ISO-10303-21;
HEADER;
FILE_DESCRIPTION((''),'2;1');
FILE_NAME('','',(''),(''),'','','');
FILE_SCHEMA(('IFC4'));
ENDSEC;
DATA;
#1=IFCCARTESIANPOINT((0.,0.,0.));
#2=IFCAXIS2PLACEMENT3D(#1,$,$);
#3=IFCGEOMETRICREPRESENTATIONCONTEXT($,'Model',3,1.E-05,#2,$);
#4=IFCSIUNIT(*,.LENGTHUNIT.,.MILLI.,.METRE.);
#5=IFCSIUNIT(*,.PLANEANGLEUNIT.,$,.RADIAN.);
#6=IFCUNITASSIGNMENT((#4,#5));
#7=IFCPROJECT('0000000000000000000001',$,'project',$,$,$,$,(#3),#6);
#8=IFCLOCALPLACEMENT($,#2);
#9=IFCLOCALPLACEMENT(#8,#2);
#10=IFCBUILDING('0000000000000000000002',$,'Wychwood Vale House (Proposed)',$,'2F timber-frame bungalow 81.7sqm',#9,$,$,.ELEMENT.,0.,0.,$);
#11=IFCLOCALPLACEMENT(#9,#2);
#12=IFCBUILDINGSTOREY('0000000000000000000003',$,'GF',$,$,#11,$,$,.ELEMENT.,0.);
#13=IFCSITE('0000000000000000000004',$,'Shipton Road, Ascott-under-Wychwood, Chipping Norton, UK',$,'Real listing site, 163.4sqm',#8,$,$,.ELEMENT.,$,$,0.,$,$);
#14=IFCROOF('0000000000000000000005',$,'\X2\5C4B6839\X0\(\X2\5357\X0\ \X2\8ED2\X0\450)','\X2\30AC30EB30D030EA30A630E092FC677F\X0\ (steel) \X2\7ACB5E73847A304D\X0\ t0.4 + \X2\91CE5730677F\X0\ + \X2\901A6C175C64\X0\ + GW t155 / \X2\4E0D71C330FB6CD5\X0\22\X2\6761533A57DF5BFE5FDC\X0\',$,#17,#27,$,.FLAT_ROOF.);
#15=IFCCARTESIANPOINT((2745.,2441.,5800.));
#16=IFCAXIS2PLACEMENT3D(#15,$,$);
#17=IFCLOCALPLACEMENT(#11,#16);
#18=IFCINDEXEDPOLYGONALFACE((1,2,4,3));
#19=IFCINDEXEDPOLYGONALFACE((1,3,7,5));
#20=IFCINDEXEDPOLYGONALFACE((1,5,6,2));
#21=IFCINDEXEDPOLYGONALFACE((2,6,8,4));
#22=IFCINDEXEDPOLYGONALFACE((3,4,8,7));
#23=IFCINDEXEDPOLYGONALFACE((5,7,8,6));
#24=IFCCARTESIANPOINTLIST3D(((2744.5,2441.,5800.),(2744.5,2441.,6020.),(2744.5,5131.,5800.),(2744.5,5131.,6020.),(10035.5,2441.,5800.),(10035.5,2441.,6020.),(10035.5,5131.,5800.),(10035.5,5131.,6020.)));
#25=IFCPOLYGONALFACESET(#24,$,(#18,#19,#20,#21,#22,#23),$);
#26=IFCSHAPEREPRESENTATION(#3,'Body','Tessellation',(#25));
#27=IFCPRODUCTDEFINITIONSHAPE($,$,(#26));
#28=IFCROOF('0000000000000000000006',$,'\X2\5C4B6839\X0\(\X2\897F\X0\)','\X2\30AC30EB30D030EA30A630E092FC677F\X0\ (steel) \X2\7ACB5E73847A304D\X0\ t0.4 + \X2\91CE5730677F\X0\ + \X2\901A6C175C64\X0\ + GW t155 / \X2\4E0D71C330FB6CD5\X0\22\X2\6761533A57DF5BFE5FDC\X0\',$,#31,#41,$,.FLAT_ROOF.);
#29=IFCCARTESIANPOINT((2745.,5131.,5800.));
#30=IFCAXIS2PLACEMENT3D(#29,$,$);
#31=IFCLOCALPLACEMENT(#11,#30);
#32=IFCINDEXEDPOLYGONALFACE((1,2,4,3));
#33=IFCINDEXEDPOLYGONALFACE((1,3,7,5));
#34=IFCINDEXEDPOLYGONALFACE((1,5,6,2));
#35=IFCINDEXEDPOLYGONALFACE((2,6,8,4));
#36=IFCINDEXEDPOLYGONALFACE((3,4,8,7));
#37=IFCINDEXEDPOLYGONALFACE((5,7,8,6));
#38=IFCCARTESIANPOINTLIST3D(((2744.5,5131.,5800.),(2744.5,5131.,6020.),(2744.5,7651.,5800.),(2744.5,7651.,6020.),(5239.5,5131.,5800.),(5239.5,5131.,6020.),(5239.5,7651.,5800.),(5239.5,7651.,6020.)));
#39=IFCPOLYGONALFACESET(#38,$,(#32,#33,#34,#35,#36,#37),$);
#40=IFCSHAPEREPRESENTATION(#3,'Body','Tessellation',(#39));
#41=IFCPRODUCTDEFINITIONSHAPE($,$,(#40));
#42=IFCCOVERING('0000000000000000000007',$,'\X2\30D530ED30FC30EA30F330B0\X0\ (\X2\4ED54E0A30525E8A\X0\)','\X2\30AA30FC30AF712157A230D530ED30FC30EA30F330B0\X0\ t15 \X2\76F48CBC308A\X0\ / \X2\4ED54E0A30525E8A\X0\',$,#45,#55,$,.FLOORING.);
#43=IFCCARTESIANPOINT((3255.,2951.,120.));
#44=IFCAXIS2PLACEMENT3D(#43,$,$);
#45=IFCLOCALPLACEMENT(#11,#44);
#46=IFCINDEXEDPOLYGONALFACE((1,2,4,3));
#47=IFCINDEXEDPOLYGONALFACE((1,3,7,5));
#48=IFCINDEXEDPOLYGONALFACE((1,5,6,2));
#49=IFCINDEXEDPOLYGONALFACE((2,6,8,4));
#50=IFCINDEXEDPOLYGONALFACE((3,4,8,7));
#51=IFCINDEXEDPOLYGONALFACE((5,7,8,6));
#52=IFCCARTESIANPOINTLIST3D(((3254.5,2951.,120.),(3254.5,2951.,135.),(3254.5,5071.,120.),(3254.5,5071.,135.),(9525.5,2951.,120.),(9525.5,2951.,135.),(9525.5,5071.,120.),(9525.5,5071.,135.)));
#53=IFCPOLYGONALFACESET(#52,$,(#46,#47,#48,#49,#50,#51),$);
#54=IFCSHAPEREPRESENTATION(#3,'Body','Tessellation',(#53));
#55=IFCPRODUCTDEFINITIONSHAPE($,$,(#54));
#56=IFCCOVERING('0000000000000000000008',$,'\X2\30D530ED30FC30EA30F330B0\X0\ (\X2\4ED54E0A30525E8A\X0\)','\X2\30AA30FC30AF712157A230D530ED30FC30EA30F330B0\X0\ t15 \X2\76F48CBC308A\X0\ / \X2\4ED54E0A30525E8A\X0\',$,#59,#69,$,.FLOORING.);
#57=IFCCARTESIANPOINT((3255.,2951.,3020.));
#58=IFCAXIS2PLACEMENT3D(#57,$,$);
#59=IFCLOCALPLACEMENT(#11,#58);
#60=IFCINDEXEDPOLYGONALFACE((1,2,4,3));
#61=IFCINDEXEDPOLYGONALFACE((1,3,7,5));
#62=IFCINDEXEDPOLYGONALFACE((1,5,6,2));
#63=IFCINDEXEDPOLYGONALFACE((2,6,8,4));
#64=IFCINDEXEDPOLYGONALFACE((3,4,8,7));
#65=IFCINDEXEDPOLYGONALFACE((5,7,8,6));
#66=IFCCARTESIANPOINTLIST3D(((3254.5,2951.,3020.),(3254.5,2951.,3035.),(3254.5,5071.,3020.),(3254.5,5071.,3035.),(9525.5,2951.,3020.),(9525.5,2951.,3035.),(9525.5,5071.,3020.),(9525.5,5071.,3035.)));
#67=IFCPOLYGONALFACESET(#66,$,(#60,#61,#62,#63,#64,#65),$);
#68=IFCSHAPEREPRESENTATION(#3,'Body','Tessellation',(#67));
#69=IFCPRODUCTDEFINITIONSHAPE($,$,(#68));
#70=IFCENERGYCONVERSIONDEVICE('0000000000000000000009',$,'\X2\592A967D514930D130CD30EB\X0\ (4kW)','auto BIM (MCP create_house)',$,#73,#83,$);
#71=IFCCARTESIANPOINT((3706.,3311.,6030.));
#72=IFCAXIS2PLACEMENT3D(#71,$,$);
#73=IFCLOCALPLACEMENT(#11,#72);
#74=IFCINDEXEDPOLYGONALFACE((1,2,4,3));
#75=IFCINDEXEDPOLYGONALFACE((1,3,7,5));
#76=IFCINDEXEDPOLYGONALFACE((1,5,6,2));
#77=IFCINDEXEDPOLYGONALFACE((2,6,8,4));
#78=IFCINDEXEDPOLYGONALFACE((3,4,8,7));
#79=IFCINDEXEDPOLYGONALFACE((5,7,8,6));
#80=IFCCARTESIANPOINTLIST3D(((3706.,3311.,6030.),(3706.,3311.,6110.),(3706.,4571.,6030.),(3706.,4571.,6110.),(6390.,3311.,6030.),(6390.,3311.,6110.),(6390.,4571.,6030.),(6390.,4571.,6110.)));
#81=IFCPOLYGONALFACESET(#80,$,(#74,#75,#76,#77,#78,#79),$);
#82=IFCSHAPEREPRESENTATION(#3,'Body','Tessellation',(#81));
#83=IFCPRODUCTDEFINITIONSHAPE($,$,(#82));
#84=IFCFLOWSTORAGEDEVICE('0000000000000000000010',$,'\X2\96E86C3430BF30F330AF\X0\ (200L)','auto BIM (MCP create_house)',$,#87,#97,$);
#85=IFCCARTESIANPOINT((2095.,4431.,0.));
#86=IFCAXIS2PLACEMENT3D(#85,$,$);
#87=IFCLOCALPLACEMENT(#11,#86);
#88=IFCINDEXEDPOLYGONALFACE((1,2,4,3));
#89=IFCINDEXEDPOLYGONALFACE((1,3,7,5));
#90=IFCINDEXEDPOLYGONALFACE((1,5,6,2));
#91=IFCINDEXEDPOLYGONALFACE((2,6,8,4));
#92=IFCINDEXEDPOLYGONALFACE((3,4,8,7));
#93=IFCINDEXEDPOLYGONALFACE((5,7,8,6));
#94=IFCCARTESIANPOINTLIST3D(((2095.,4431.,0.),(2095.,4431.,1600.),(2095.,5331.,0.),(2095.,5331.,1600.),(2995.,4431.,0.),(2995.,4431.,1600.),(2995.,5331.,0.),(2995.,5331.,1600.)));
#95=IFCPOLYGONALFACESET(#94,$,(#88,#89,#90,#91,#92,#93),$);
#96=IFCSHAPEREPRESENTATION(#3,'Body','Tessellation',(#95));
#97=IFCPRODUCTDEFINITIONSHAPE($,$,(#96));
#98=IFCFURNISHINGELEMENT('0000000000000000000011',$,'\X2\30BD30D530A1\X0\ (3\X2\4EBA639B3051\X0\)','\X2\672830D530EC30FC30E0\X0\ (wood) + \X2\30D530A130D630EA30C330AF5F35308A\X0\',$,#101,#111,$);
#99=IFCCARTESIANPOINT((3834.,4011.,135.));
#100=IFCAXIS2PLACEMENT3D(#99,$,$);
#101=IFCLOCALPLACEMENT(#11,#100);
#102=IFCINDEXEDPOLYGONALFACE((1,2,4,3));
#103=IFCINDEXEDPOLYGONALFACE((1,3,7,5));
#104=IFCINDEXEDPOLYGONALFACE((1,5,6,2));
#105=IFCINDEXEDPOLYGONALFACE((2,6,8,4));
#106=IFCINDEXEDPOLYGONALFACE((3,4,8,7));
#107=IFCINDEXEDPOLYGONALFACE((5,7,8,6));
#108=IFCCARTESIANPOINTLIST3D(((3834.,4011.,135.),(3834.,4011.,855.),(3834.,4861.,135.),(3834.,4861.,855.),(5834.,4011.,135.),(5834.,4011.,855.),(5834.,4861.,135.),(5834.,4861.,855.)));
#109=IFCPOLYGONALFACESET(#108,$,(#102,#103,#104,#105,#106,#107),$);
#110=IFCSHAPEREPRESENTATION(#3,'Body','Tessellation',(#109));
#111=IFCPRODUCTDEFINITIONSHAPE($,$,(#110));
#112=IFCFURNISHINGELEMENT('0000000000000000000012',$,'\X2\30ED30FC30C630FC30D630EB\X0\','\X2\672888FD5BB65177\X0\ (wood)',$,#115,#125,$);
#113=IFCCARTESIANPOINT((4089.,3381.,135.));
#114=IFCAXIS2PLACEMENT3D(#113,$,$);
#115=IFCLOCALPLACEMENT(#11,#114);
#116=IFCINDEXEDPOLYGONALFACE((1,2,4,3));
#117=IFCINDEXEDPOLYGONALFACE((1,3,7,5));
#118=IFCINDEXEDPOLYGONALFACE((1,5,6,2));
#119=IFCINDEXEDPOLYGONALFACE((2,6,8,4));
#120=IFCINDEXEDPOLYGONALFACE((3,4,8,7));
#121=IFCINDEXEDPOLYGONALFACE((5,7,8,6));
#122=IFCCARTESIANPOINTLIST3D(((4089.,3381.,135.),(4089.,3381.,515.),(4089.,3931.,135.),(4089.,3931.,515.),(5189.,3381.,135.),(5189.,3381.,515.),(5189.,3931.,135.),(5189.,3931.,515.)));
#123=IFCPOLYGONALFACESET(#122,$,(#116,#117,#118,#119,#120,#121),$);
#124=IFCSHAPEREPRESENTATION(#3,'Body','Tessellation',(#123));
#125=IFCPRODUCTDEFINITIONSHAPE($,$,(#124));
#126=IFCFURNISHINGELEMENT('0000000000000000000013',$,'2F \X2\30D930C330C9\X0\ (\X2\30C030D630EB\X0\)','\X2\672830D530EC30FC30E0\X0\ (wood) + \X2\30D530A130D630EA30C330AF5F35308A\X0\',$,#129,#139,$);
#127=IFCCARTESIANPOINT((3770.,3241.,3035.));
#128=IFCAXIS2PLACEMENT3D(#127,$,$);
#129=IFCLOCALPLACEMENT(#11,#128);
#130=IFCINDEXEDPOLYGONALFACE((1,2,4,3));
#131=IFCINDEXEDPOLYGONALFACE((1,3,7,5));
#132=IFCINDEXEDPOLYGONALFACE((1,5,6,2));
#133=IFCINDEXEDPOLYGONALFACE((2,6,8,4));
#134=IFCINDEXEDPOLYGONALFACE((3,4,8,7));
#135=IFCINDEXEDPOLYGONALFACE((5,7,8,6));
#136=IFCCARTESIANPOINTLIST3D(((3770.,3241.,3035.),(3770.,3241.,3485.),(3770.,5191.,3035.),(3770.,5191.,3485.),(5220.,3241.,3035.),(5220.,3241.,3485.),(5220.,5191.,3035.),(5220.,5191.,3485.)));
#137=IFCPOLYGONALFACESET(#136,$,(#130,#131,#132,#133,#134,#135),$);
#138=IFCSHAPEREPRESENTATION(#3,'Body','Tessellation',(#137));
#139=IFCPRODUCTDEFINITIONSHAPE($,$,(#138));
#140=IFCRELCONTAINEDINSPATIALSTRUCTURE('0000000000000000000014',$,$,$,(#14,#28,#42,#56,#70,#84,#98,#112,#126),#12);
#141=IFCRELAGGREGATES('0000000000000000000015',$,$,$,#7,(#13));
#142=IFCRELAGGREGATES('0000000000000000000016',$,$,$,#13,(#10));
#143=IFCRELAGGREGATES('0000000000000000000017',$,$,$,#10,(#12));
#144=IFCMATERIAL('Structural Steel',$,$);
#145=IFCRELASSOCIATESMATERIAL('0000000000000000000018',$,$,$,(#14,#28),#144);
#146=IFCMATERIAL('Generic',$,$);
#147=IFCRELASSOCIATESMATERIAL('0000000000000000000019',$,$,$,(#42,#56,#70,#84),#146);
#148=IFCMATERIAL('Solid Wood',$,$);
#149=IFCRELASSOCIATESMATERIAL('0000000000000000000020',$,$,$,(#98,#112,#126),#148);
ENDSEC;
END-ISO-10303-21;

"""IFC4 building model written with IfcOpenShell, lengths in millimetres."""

from ifc_helpers import new_model, si_unit, frame, frame_2d, origin, place, context, project, spatial, rectangle, extrude, material, element, save


model = new_model("IFC4")

# Units and contexts
model_context = context("Model", 3, precision=1e-05, world=origin())
ifc_project = project(units=[si_unit("LENGTHUNIT", "METRE", prefix="MILLI"), si_unit("PLANEANGLEUNIT", "RADIAN")], contexts=[model_context])

# Site, building, storey
site_placement = place(None, origin())
site = spatial("IfcSite", under=ifc_project, at=site_placement, Name="Shipton Road, Ascott-under-Wychwood, Chipping Norton, UK", ObjectType="Real listing site, 163.4sqm", CompositionType="ELEMENT", RefElevation=0.0)
building_placement = place(site_placement, origin())
building = spatial("IfcBuilding", under=site, at=building_placement, Name="Wychwood Vale House (Proposed)", ObjectType="2F timber-frame bungalow 81.7sqm", CompositionType="ELEMENT", ElevationOfRefHeight=0.0, ElevationOfTerrain=0.0)
storey_placement = place(building_placement, origin())
storey = spatial("IfcBuildingStorey", under=building, at=storey_placement, Name="GF", CompositionType="ELEMENT", Elevation=0.0)

# Shared definitions
ifc_material_1 = material(Name="Solid Wood")

# Roofs
ifc_material_2 = material(Name="Structural Steel")
roof_1_placement = place(storey_placement, frame((2745.0, 2441.0, 5800.0)))
element("IfcRoof", 1, at=roof_1_placement, inside=storey, material=ifc_material_2, Name="屋根(南 軒450)", Description="ガルバリウム鋼板 (steel) 立平葺き t0.4 + 野地板 + 通気層 + GW t155 / 不燃・法22条区域対応", PredefinedType="FLAT_ROOF", context=model_context, shape_type="SweptSolid", body=[
    extrude(rectangle(XDim=7291.0, YDim=2690.0, at=frame_2d((3645.0, 1345.0))), frame((2745.0, 2441.0, 5800.0)), (0.0, 0.0, 1.0), 220.0),
])
roof_2_placement = place(storey_placement, frame((2745.0, 5131.0, 5800.0)))
element("IfcRoof", 2, at=roof_2_placement, inside=storey, material=ifc_material_2, Name="屋根(西)", Description="ガルバリウム鋼板 (steel) 立平葺き t0.4 + 野地板 + 通気層 + GW t155 / 不燃・法22条区域対応", PredefinedType="FLAT_ROOF", context=model_context, shape_type="SweptSolid", body=[
    extrude(rectangle(XDim=2495.0, YDim=2520.0, at=frame_2d((1247.0, 1260.0))), frame((2745.0, 5131.0, 5800.0)), (0.0, 0.0, 1.0), 220.0),
])

# Coverings
ifc_material_3 = material(Name="Generic")
covering_1_placement = place(storey_placement, frame((3255.0, 2951.0, 120.0)))
element("IfcCovering", 3, at=covering_1_placement, inside=storey, material=ifc_material_3, Name="フローリング (仕上げ床)", Description="オーク無垢フローリング t15 直貼り / 仕上げ床", PredefinedType="FLOORING", context=model_context, shape_type="SweptSolid", body=[
    extrude(rectangle(XDim=6271.0, YDim=2120.0, at=frame_2d((3135.0, 1060.0))), frame((3255.0, 2951.0, 120.0)), (0.0, 0.0, 1.0), 15.0),
])
covering_2_placement = place(storey_placement, frame((3255.0, 2951.0, 3020.0)))
element("IfcCovering", 4, at=covering_2_placement, inside=storey, material=ifc_material_3, Name="フローリング (仕上げ床)", Description="オーク無垢フローリング t15 直貼り / 仕上げ床", PredefinedType="FLOORING", context=model_context, shape_type="SweptSolid", body=[
    extrude(rectangle(XDim=6271.0, YDim=2120.0, at=frame_2d((3135.0, 1060.0))), frame((3255.0, 2951.0, 3020.0)), (0.0, 0.0, 1.0), 15.0),
])

# Energy conversion device
energy_conversion_device_placement = place(storey_placement, frame((3706.0, 3311.0, 6030.0)))
element("IfcEnergyConversionDevice", 5, at=energy_conversion_device_placement, inside=storey, material=ifc_material_3, Name="太陽光パネル (4kW)", Description="auto BIM (MCP create_house)", context=model_context, shape_type="SweptSolid", body=[
    extrude(rectangle(XDim=2684.0, YDim=1260.0, at=frame_2d((1342.0, 630.0))), frame((3706.0, 3311.0, 6030.0)), (0.0, 0.0, 1.0), 80.0),
])

# Flow storage device
flow_storage_device_placement = place(storey_placement, frame((2095.0, 4431.0, 0.0)))
element("IfcFlowStorageDevice", 6, at=flow_storage_device_placement, inside=storey, material=ifc_material_3, Name="雨水タンク (200L)", Description="auto BIM (MCP create_house)", context=model_context, shape_type="SweptSolid", body=[
    extrude(rectangle(XDim=900.0, YDim=900.0, at=frame_2d((450.0, 450.0))), frame((2095.0, 4431.0, 0.0)), (0.0, 0.0, 1.0), 1600.0),
])

# Furnishing elements
furnishing_1_placement = place(storey_placement, frame((3834.0, 4011.0, 135.0)))
element("IfcFurnishingElement", 7, at=furnishing_1_placement, inside=storey, material=ifc_material_1, Name="ソファ (3人掛け)", Description="木フレーム (wood) + ファブリック張り", context=model_context, shape_type="SweptSolid", body=[
    extrude(rectangle(XDim=2000.0, YDim=850.0, at=frame_2d((1000.0, 425.0))), frame((3834.0, 4011.0, 135.0)), (0.0, 0.0, 1.0), 720.0),
])
furnishing_2_placement = place(storey_placement, frame((4089.0, 3381.0, 135.0)))
element("IfcFurnishingElement", 8, at=furnishing_2_placement, inside=storey, material=ifc_material_1, Name="ローテーブル", Description="木製家具 (wood)", context=model_context, shape_type="SweptSolid", body=[
    extrude(rectangle(XDim=1100.0, YDim=550.0, at=frame_2d((550.0, 275.0))), frame((4089.0, 3381.0, 135.0)), (0.0, 0.0, 1.0), 380.0),
])
furnishing_3_placement = place(storey_placement, frame((3770.0, 3241.0, 3035.0)))
element("IfcFurnishingElement", 9, at=furnishing_3_placement, inside=storey, material=ifc_material_1, Name="2F ベッド (ダブル)", Description="木フレーム (wood) + ファブリック張り", context=model_context, shape_type="SweptSolid", body=[
    extrude(rectangle(XDim=1450.0, YDim=1950.0, at=frame_2d((725.0, 975.0))), frame((3770.0, 3241.0, 3035.0)), (0.0, 0.0, 1.0), 450.0),
])

save(model, "model.ifc")
